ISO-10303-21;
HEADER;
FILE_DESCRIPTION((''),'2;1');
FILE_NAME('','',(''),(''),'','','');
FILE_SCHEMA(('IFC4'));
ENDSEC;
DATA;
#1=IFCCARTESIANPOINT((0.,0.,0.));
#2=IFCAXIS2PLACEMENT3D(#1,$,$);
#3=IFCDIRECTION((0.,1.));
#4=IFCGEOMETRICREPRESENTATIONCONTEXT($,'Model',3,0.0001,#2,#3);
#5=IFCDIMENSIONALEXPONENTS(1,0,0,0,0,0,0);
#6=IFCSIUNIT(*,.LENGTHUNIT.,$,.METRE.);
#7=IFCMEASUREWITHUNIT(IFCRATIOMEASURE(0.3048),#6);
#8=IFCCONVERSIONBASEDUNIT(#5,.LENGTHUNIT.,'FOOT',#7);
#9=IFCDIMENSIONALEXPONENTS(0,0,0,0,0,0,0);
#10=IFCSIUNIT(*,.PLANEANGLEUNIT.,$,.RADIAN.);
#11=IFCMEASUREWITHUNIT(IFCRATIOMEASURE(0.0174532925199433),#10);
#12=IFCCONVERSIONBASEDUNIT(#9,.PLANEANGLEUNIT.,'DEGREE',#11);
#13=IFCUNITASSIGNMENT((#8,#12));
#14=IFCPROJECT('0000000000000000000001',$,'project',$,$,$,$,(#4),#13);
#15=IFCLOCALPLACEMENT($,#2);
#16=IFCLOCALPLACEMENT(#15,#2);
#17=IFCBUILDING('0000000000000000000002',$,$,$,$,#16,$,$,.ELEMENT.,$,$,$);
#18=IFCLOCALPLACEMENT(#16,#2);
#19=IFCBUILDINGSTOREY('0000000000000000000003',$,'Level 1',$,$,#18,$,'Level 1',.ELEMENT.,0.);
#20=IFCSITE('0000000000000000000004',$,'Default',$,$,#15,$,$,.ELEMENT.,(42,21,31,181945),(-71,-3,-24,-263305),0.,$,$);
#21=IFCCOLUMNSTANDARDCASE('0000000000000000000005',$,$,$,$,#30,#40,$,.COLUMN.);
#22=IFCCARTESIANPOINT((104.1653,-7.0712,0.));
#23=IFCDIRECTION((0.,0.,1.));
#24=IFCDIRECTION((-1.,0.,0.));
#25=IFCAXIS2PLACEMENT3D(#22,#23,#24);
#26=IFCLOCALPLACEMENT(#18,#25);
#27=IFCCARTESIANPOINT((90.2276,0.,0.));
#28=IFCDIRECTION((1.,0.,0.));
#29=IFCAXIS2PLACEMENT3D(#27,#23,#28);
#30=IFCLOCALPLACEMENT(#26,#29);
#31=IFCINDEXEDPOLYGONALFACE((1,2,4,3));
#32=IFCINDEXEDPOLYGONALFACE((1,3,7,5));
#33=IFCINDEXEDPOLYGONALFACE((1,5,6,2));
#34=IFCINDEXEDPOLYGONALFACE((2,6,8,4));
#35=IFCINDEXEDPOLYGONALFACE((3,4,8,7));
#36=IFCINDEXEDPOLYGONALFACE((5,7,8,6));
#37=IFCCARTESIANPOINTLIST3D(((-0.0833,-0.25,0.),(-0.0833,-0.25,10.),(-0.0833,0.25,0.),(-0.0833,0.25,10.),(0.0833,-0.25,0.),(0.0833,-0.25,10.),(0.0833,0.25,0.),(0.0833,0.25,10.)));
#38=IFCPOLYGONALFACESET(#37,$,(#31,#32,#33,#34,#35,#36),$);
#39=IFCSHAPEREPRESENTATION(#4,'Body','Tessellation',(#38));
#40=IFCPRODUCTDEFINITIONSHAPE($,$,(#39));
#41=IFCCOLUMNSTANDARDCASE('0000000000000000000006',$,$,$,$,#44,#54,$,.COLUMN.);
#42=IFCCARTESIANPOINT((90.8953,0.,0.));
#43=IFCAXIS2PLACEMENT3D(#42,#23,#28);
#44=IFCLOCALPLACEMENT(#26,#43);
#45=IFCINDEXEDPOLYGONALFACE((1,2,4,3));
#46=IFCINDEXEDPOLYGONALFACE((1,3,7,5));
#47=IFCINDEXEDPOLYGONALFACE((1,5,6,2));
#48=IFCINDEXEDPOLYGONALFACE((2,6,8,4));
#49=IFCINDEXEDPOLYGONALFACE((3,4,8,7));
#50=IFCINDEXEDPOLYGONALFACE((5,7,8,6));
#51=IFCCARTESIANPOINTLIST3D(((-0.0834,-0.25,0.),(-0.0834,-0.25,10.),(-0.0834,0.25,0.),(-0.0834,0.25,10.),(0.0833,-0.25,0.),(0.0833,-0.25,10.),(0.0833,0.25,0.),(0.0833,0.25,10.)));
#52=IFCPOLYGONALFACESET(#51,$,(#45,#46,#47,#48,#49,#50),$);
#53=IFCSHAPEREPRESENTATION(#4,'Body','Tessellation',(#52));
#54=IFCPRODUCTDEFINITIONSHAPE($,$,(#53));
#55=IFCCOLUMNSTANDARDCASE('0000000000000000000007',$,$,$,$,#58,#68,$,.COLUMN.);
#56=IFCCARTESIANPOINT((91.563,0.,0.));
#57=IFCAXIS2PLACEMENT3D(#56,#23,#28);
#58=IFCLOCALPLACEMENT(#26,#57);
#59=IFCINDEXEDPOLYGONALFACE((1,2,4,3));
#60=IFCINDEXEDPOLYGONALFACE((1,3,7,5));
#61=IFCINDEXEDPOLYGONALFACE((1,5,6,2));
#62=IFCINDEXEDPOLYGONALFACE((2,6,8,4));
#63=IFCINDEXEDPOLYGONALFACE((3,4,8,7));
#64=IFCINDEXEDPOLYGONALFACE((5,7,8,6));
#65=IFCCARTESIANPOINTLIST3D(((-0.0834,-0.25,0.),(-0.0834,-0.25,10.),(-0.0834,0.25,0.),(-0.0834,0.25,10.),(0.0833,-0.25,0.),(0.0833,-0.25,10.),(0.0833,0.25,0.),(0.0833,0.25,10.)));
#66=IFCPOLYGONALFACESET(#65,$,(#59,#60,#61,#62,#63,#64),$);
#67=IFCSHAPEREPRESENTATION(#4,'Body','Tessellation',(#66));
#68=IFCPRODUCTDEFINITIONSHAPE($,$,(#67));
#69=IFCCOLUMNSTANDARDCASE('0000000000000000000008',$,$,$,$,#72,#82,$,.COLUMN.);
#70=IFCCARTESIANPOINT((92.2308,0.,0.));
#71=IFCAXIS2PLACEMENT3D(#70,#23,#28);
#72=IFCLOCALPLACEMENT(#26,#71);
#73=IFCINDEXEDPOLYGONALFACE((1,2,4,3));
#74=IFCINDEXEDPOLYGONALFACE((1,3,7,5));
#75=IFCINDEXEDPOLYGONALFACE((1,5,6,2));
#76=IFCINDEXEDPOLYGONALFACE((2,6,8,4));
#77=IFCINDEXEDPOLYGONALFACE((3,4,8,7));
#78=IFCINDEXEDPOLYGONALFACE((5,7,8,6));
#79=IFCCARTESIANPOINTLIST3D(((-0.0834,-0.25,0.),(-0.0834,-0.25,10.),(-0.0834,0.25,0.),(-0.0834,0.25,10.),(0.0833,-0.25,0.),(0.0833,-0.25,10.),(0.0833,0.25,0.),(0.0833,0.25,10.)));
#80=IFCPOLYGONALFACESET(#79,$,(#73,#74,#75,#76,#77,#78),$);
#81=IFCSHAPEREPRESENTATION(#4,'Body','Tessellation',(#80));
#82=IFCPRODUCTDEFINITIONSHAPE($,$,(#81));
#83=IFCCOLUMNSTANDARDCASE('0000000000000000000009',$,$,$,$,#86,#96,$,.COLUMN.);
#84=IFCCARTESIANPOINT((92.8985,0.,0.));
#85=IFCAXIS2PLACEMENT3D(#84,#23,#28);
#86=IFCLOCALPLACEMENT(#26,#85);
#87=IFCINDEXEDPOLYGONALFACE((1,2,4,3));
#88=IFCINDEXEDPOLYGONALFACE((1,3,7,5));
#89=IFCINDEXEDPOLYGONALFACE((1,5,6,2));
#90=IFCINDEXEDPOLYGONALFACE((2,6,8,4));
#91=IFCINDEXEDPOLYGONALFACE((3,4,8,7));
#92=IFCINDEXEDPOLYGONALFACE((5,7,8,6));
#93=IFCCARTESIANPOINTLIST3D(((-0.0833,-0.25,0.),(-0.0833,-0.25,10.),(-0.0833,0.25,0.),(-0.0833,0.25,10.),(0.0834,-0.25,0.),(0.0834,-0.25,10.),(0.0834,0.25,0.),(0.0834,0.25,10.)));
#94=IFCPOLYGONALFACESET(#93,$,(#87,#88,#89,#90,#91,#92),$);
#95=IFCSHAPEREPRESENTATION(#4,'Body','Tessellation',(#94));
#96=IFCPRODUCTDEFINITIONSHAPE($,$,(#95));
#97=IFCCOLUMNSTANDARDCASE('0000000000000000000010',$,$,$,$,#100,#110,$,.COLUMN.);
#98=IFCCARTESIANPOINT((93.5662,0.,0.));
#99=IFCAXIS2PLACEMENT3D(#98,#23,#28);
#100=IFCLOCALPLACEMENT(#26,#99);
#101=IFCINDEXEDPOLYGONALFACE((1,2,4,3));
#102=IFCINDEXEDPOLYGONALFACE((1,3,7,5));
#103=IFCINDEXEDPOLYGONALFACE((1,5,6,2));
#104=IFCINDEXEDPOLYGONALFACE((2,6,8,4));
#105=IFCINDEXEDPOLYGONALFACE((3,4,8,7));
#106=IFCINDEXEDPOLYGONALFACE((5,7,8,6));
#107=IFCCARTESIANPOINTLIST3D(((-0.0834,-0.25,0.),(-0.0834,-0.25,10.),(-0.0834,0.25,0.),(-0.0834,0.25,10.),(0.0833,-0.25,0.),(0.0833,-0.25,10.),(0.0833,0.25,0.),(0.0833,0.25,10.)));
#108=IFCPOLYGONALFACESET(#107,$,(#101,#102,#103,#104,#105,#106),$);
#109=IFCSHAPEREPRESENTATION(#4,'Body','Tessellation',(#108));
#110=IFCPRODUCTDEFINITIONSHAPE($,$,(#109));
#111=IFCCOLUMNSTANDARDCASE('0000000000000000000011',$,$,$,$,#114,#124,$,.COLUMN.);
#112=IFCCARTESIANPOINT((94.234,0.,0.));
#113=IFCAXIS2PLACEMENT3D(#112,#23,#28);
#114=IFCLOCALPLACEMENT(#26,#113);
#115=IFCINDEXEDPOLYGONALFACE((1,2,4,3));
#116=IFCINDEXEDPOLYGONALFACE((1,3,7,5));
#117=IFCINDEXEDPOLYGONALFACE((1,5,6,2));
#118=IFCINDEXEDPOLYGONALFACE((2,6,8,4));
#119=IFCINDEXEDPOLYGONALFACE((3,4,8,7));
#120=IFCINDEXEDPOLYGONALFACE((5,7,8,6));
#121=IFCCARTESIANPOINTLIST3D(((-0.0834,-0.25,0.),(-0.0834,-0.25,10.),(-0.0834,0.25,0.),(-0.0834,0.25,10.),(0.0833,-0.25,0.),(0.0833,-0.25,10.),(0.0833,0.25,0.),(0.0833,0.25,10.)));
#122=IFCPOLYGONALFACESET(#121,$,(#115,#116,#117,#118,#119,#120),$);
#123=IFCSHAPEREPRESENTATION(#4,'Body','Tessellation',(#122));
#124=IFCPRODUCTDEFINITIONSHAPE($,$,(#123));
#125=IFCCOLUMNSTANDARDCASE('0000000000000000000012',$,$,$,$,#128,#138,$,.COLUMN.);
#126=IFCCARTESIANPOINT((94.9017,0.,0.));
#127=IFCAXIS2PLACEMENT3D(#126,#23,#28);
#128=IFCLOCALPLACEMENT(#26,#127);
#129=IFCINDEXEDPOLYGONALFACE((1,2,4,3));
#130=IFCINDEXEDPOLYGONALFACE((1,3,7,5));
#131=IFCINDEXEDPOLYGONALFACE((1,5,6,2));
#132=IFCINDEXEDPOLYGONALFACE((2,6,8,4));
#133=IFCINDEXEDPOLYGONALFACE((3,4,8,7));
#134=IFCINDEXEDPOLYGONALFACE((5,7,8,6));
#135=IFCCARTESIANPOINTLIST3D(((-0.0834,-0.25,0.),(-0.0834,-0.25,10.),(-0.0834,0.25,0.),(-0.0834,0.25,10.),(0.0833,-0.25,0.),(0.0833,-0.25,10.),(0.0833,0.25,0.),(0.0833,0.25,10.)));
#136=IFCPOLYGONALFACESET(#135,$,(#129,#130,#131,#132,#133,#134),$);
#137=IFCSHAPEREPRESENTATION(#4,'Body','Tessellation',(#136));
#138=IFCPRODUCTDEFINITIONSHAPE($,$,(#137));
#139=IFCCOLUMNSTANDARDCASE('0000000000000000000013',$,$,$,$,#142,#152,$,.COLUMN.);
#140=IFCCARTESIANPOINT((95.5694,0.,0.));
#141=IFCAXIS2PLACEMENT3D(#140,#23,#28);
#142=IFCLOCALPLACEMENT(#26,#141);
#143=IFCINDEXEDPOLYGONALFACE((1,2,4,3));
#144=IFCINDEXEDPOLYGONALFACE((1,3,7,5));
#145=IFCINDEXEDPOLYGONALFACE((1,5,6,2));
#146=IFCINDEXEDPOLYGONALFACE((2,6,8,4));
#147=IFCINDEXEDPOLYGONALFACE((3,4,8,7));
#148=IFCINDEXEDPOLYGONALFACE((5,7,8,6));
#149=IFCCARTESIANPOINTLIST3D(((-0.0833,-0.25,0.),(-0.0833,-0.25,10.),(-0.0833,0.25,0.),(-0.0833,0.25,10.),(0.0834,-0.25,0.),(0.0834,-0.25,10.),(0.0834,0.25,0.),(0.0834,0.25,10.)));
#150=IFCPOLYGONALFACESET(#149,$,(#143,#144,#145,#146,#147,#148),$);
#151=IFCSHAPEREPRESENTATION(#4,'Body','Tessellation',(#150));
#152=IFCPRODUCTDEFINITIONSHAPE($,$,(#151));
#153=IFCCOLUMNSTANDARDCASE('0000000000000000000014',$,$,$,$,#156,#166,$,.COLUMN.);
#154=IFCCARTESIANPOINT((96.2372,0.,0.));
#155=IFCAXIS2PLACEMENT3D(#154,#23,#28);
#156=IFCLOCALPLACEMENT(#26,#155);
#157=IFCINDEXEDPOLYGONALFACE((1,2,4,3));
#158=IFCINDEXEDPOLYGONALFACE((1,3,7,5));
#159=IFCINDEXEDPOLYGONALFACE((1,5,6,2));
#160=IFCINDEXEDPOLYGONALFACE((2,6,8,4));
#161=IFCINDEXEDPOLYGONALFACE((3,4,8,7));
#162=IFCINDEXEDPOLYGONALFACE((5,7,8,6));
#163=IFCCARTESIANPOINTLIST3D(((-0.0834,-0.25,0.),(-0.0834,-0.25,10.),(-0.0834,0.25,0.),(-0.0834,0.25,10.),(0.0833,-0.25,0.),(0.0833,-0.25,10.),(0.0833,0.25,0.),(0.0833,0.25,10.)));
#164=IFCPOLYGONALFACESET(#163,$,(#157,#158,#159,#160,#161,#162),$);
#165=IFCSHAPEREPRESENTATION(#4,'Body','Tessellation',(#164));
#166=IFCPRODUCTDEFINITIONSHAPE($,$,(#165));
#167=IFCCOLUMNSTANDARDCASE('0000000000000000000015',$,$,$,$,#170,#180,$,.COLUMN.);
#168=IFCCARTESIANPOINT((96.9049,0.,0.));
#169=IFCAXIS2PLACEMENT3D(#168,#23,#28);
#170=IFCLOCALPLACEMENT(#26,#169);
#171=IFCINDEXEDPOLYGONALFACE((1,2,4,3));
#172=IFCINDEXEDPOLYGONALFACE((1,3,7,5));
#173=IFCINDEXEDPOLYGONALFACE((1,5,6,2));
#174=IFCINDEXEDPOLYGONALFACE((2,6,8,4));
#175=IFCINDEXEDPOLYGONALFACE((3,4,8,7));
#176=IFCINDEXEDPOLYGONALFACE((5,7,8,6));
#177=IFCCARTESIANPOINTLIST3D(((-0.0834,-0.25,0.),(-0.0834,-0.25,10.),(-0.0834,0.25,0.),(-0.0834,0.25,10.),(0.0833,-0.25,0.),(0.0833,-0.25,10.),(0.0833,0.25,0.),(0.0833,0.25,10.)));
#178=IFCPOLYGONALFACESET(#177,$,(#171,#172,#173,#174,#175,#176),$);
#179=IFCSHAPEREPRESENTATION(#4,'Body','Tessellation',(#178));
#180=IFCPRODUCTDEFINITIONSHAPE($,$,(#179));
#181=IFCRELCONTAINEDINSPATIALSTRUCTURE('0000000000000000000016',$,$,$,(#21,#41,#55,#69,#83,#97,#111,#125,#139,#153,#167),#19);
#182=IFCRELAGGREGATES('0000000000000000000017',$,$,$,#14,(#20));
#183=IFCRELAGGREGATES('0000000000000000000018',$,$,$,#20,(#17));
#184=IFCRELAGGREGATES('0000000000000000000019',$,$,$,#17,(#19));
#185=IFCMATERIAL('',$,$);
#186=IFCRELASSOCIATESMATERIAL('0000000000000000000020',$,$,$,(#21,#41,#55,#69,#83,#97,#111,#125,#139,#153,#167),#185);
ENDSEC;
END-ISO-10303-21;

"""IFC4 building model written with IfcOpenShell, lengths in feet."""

from ifc_helpers import new_model, entity, si_unit, converted_unit, direction, frame, origin, place, context, project, spatial, rectangle, extrude, material, element, save


model = new_model("IFC4")

# Units and contexts
model_context = context("Model", 3, precision=0.0001, world=origin(), true_north=direction((0.0, 1.0)))
ifc_project = project(units=[converted_unit("LENGTHUNIT", "FOOT", entity("IfcRatioMeasure", 0.3048), si_unit("LENGTHUNIT", "METRE"), dimensions=[1, 0, 0, 0, 0, 0, 0]), converted_unit("PLANEANGLEUNIT", "DEGREE", entity("IfcRatioMeasure", 0.0174532925199433), si_unit("PLANEANGLEUNIT", "RADIAN"), dimensions=[0, 0, 0, 0, 0, 0, 0])], contexts=[model_context])

# Site, building, storey
site_placement = place(None, origin())
site = spatial("IfcSite", under=ifc_project, at=site_placement, Name="Default", CompositionType="ELEMENT", RefLatitude=(42, 21, 31, 181945), RefLongitude=(-71, -3, -24, -263305), RefElevation=0.0)
building_placement = place(site_placement, origin())
building = spatial("IfcBuilding", under=site, at=building_placement, CompositionType="ELEMENT")
storey_placement = place(building_placement, origin())
storey = spatial("IfcBuildingStorey", under=building, at=storey_placement, Name="Level 1", LongName="Level 1", CompositionType="ELEMENT", Elevation=0.0)

# Columns
ifc_material = material(Name="")
placement = place(storey_placement, frame((104.1653, -7.0712, 0.0), z_axis=(0.0, 0.0, 1.0), x_axis=(-1.0, 0.0, 0.0)))
for number, where, z_axis, x_axis in (
    (1, (90.2276, 0.0, 0.0), (0.0, 0.0, 1.0), (1.0, 0.0, 0.0)),
    (2, (90.8953, 0.0, 0.0), (0.0, 0.0, 1.0), (1.0, 0.0, 0.0)),
    (3, (91.563, 0.0, 0.0), (0.0, 0.0, 1.0), (1.0, 0.0, 0.0)),
    (4, (92.2308, 0.0, 0.0), (0.0, 0.0, 1.0), (1.0, 0.0, 0.0)),
    (5, (92.8985, 0.0, 0.0), (0.0, 0.0, 1.0), (1.0, 0.0, 0.0)),
    (6, (93.5662, 0.0, 0.0), (0.0, 0.0, 1.0), (1.0, 0.0, 0.0)),
    (7, (94.234, 0.0, 0.0), (0.0, 0.0, 1.0), (1.0, 0.0, 0.0)),
    (8, (94.9017, 0.0, 0.0), (0.0, 0.0, 1.0), (1.0, 0.0, 0.0)),
    (9, (95.5694, 0.0, 0.0), (0.0, 0.0, 1.0), (1.0, 0.0, 0.0)),
    (10, (96.2372, 0.0, 0.0), (0.0, 0.0, 1.0), (1.0, 0.0, 0.0)),
    (11, (96.9049, 0.0, 0.0), (0.0, 0.0, 1.0), (1.0, 0.0, 0.0)),
):
    element("IfcColumnStandardCase", number, at=place(placement, frame(where, z_axis=z_axis, x_axis=x_axis)), inside=storey, material=ifc_material, PredefinedType="COLUMN", context=model_context, shape_type="SweptSolid", body=[
        extrude(rectangle(XDim=0.1667, YDim=0.5), origin(), (0.0, 0.0, 1.0), 10.0),
    ])

save(model, "model.ifc")
